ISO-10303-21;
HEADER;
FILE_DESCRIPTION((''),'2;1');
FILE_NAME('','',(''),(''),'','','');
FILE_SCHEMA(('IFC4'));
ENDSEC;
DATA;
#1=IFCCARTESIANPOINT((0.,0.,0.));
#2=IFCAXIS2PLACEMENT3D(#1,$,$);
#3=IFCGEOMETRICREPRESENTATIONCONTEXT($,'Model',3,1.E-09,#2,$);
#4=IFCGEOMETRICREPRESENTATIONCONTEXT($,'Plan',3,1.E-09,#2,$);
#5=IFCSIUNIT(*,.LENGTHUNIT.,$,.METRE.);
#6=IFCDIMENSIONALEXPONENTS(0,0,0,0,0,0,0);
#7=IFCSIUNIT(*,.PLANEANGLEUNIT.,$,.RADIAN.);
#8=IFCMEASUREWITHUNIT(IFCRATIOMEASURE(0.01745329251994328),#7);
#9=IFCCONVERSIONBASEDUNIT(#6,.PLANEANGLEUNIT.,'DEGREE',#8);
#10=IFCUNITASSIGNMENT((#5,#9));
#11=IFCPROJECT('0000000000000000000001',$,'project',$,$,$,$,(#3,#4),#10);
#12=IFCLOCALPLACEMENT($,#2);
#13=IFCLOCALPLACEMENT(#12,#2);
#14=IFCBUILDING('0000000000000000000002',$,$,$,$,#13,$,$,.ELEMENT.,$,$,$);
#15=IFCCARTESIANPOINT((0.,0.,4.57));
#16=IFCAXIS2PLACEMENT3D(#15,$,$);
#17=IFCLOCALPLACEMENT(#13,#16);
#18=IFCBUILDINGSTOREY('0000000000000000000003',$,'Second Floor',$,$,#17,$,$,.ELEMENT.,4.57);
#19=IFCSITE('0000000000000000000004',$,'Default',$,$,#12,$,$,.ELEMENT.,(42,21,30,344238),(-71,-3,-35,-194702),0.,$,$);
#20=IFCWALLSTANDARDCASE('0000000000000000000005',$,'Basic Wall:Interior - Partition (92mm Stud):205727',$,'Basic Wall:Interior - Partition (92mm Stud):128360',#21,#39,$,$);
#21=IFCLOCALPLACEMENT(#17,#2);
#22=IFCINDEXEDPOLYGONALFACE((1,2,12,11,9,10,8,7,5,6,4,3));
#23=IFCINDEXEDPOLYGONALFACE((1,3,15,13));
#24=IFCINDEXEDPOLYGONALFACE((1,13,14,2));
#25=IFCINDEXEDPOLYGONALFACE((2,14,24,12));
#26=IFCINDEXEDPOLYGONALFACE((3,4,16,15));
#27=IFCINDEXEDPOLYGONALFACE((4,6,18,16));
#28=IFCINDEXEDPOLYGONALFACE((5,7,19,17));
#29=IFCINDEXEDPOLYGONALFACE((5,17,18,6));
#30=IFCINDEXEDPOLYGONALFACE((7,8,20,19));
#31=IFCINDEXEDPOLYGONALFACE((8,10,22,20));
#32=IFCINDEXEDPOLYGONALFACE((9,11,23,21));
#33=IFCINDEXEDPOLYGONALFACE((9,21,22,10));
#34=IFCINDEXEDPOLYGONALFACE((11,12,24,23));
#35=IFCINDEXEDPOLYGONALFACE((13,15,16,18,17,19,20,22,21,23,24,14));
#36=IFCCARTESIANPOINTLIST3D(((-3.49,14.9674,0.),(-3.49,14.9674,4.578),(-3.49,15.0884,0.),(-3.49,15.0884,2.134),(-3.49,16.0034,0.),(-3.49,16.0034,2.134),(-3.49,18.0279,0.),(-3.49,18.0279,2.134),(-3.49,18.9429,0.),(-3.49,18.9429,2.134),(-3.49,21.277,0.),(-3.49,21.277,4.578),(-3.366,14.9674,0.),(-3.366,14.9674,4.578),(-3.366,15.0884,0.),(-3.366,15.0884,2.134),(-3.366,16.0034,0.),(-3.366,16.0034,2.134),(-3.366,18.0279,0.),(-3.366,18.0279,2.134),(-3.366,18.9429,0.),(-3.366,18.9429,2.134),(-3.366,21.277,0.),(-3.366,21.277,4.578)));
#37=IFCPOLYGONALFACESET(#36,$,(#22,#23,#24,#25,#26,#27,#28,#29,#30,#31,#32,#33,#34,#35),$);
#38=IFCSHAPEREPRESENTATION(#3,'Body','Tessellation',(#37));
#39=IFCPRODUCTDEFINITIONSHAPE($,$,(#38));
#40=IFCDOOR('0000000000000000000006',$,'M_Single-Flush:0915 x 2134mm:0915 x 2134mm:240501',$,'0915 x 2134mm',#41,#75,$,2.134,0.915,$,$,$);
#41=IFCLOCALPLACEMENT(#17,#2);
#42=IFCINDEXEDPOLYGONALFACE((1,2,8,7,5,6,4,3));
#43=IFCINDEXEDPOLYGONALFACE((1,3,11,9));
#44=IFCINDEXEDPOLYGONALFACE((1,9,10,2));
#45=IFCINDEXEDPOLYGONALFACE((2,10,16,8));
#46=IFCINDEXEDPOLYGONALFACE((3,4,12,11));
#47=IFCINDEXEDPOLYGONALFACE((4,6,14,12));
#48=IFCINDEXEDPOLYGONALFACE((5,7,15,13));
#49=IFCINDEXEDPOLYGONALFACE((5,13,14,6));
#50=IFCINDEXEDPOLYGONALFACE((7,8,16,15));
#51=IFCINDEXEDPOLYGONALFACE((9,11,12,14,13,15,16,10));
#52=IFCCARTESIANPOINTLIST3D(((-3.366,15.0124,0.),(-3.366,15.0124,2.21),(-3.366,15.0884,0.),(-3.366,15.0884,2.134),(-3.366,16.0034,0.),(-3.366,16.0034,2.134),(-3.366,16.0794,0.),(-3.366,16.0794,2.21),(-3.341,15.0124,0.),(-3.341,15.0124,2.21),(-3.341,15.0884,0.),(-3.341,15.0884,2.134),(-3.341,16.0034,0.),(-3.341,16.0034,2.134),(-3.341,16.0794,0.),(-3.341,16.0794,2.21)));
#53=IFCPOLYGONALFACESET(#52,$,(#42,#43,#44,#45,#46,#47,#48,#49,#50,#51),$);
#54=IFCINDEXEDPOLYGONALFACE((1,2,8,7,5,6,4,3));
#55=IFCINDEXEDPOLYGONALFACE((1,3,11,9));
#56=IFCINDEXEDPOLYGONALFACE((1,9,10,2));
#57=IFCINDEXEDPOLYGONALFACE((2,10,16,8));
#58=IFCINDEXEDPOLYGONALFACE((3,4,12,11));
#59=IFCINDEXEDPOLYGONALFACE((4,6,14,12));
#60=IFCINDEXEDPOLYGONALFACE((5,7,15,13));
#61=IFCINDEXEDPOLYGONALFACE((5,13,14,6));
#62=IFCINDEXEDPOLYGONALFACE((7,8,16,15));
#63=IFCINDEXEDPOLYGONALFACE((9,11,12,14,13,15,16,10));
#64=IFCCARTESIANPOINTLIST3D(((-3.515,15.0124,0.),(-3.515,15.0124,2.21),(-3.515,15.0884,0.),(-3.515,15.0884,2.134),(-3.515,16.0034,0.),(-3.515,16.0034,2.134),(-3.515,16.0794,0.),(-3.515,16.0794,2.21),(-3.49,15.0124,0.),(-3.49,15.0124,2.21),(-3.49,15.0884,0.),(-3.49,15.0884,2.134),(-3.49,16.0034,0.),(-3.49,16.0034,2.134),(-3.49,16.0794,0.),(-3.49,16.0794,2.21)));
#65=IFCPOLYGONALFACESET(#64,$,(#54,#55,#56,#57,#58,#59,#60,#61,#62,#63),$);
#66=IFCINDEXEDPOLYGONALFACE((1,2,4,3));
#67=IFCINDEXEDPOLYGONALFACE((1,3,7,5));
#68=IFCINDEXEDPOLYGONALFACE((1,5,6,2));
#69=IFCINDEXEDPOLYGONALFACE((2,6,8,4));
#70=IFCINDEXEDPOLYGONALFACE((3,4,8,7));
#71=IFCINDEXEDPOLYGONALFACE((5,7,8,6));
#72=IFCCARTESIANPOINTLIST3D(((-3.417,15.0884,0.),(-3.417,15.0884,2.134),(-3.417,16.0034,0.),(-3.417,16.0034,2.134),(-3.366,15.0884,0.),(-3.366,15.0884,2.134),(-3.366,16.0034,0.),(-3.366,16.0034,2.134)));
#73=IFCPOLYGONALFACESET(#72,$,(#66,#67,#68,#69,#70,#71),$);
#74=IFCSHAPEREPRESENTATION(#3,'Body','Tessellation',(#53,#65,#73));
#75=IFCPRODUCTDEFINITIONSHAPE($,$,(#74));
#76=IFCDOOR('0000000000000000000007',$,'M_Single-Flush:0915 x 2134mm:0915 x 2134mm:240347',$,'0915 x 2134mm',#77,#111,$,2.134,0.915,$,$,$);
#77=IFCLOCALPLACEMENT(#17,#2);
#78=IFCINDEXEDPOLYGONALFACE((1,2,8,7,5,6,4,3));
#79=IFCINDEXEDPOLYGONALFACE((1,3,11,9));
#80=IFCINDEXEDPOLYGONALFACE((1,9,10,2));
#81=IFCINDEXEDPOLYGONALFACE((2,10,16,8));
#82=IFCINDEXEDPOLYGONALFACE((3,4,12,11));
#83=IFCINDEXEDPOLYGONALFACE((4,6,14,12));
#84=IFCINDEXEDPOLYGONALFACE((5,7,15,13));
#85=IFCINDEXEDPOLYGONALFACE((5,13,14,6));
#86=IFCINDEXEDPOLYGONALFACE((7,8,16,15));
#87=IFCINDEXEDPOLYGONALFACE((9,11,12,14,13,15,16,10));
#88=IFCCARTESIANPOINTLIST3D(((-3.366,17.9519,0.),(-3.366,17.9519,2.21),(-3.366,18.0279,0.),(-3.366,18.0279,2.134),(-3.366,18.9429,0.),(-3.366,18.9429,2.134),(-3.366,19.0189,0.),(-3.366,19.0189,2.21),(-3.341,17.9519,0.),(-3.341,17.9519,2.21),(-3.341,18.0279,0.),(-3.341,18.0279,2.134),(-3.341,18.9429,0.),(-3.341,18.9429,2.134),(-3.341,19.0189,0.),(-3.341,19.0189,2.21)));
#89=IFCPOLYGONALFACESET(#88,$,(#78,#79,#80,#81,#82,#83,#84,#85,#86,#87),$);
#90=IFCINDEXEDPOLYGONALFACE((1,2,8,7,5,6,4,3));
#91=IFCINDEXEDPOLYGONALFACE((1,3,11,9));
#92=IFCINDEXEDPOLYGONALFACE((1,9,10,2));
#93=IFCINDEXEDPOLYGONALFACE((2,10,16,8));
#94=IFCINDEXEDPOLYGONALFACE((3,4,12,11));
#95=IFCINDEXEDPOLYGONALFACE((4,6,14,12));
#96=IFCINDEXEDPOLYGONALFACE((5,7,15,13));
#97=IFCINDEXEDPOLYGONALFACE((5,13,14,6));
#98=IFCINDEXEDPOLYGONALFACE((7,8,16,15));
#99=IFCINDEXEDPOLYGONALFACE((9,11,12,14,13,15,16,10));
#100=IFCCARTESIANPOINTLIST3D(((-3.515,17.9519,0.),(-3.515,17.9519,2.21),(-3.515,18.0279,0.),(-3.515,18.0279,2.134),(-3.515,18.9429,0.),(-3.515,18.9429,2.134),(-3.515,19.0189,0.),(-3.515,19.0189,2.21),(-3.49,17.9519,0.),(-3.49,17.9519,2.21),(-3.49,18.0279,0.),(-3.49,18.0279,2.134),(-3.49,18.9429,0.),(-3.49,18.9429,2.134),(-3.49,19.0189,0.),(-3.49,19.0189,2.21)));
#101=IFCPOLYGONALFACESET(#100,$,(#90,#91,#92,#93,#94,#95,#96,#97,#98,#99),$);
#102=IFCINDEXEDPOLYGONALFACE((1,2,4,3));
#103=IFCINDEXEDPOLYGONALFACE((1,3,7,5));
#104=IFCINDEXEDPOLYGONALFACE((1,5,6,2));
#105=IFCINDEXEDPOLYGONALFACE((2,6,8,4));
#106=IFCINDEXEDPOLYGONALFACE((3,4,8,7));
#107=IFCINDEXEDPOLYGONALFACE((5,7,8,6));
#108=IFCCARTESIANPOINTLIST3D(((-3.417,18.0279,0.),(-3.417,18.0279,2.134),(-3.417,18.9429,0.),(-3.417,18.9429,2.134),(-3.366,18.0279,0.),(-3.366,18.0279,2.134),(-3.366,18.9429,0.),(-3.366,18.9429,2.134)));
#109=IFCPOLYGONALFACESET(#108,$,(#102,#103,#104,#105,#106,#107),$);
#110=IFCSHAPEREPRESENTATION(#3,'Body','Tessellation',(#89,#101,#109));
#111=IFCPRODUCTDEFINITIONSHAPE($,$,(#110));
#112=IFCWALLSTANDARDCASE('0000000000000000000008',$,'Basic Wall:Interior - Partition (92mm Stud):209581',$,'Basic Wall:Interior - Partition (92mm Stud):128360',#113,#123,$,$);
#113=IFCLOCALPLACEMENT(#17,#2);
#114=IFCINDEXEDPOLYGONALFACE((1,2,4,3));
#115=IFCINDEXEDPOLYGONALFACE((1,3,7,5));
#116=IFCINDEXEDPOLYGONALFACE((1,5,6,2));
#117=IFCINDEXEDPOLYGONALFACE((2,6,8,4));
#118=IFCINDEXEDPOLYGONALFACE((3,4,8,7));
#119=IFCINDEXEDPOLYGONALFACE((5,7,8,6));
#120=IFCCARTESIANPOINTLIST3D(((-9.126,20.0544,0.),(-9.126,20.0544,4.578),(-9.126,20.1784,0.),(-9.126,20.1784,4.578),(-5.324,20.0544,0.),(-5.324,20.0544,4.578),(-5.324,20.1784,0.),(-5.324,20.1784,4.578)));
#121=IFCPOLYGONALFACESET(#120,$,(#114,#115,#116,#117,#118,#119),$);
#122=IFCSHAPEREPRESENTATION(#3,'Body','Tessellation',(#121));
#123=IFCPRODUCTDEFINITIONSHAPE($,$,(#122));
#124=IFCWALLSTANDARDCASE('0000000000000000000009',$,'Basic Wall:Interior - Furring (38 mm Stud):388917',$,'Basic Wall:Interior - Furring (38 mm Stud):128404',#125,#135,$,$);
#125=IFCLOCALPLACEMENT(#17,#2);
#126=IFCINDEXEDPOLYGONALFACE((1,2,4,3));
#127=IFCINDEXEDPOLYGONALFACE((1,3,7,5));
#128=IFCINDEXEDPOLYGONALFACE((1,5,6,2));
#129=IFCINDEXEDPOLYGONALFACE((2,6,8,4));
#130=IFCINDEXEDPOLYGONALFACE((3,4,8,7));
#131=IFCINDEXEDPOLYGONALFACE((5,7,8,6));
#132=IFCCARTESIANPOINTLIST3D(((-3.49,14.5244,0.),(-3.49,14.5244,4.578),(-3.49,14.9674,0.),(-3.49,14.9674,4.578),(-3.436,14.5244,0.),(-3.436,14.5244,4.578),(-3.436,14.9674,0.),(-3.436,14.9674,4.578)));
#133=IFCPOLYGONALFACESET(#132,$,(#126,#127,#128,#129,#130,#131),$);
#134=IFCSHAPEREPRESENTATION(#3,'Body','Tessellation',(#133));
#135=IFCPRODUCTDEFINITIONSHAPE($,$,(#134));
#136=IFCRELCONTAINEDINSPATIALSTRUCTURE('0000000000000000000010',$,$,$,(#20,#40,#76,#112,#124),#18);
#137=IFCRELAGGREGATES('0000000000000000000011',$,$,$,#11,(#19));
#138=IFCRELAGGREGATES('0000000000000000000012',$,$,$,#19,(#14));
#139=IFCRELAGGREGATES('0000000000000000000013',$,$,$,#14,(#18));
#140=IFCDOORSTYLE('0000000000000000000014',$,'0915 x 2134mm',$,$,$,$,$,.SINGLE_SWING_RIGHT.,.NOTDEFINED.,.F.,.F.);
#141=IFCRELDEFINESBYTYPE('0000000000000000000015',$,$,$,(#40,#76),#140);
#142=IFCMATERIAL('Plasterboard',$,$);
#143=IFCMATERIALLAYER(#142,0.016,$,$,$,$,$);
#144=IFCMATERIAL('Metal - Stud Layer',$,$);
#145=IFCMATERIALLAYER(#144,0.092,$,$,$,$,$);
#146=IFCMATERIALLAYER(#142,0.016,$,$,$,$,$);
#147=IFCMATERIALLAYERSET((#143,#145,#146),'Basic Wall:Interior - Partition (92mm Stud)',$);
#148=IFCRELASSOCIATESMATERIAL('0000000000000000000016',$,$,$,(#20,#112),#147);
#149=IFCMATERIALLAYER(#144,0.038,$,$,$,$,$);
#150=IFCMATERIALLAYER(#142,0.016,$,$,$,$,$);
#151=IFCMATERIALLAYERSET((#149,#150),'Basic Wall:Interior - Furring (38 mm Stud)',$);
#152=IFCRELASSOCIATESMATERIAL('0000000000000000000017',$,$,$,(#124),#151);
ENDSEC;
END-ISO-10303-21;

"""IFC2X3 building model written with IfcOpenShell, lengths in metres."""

from ifc_helpers import new_model, entity, si_unit, converted_unit, frame, frame_2d, origin, origin_2d_with_axis, place, context, project, spatial, polyline, rectangle, outline, extrude, source, transform, mapped, material, layer, layer_set, layer_usage, type_object, type_shapes, element, fill, save


model = new_model("IFC2X3")

# Units and contexts
model_context = context("Model", 3, precision=1e-09, world=origin())
plan_context = context("Plan", 3, precision=1e-09, world=origin())
ifc_project = project(units=[si_unit("LENGTHUNIT", "METRE"), converted_unit("PLANEANGLEUNIT", "DEGREE", entity("IfcRatioMeasure", 0.01745329251994328), si_unit("PLANEANGLEUNIT", "RADIAN"), dimensions=[0, 0, 0, 0, 0, 0, 0])], contexts=[model_context, plan_context])

# Site, building, storey
site_placement = place(None, origin())
site = spatial("IfcSite", under=ifc_project, at=site_placement, Name="Default", CompositionType="ELEMENT", RefLatitude=(42, 21, 30, 344238), RefLongitude=(-71, -3, -35, -194702), RefElevation=0.0)
building_placement = place(site_placement, origin())
building = spatial("IfcBuilding", under=site, at=building_placement, CompositionType="ELEMENT")
storey_placement = place(building_placement, frame((0.0, 0.0, 4.57)))
storey = spatial("IfcBuildingStorey", under=building, at=storey_placement, Name="Second Floor", CompositionType="ELEMENT", Elevation=4.57)

# Wall, openings, doors
ifc_material_1 = material(Name="Plasterboard")
ifc_layer_1 = layer(ifc_material_1, 0.016)
ifc_material_2 = material(Name="Metal - Stud Layer")
ifc_layer_2 = layer(ifc_material_2, 0.092)
ifc_layer_3 = layer(ifc_material_1, 0.016)
ifc_layer_set_1 = layer_set([ifc_layer_1, ifc_layer_2, ifc_layer_3], Name="Basic Wall:Interior - Partition (92mm Stud)")
ifc_layer_usage_1 = layer_usage(ifc_layer_set_1, "AXIS2", "NEGATIVE", 0.062)
wall_1_placement = place(storey_placement, frame((-3.428, 21.277, 0.0), z_axis=(0.0, 0.0, 1.0), x_axis=(0.0, -1.0, 0.0)))
wall_1 = element("IfcWallStandardCase", 1, at=wall_1_placement, inside=storey, material=ifc_layer_usage_1, Name="Basic Wall:Interior - Partition (92mm Stud):205727", ObjectType="Basic Wall:Interior - Partition (92mm Stud):128360", context=model_context, shape_type="SweptSolid", body=[
    extrude(rectangle(XDim=6.3096, YDim=0.124, at=frame_2d((3.1548, 0.0), x_axis=(-1.0, 0.0))), origin(), (0.0, 0.0, 1.0), 4.578),
])
opening_1_placement = place(wall_1_placement, frame((2.3341, -0.062, 0.0)))
opening_1 = element("IfcOpeningElement", 2, at=opening_1_placement, cuts=wall_1, ObjectType="Opening", context=model_context, shape_type="SweptSolid", body=[
    extrude(rectangle(XDim=0.915, YDim=2.134, at=frame_2d((1.067, 0.4575), x_axis=(0.0, 1.0))), frame((0.0, 0.0, 0.0), z_axis=(0.0, 1.0, 0.0), x_axis=(0.0, 0.0, 1.0)), (0.0, 0.0, 1.0), 0.124),
])
opening_2_placement = place(wall_1_placement, frame((5.2736, -0.062, 0.0)))
opening_2 = element("IfcOpeningElement", 3, at=opening_2_placement, cuts=wall_1, ObjectType="Opening", context=model_context, shape_type="SweptSolid", body=[
    extrude(rectangle(XDim=0.915, YDim=2.134, at=frame_2d((1.067, 0.4575), x_axis=(0.0, 1.0))), frame((0.0, 0.0, 0.0), z_axis=(0.0, 1.0, 0.0), x_axis=(0.0, 0.0, 1.0)), (0.0, 0.0, 1.0), 0.124),
])
door_style_1 = type_object("IfcDoorStyle", Name="0915 x 2134mm", ConstructionType="NOTDEFINED", OperationType="SINGLE_SWING_RIGHT", ParameterTakesPrecedence=False, Sizeable=False)
shared_shape_1 = source(origin(), model_context, "Body", "SweptSolid", [
    extrude(outline(polyline([(-0.5335, -1.124), (0.5335, -1.124), (0.5335, 1.086), (0.4575, 1.086), (0.4575, -1.048), (-0.4575, -1.048), (-0.4575, 1.086), (-0.5335, 1.086), (-0.5335, -1.124)])), frame((0.4575, 0.124, 1.086), z_axis=(0.0, 1.0, 0.0), x_axis=(1.0, 0.0, 0.0)), (0.0, 0.0, 1.0), 0.025),
    extrude(outline(polyline([(-1.124, -0.5335), (1.086, -0.5335), (1.086, -0.4575), (-1.048, -0.4575), (-1.048, 0.4575), (1.086, 0.4575), (1.086, 0.5335), (-1.124, 0.5335), (-1.124, -0.5335)])), frame((0.4575, -0.025, 1.086), z_axis=(0.0, 1.0, 0.0), x_axis=(0.0, 0.0, -1.0)), (0.0, 0.0, 1.0), 0.025),
    extrude(rectangle(XDim=0.051, YDim=0.915, at=origin_2d_with_axis()), frame((0.4575, 0.0985, 0.0), z_axis=(0.0, 0.0, 1.0), x_axis=(0.0, 1.0, 0.0)), (0.0, 0.0, 1.0), 2.134),
])
type_shapes(door_style_1, [shared_shape_1])
door_1_placement = place(opening_2_placement, origin())
door_1 = element("IfcDoor", 4, at=door_1_placement, inside=storey, type_object=door_style_1, Name="M_Single-Flush:0915 x 2134mm:0915 x 2134mm:240501", ObjectType="0915 x 2134mm", OverallHeight=2.134, OverallWidth=0.915, context=model_context, shape_type="MappedRepresentation", body=[
    mapped(shared_shape_1, transform((0.0, 0.0, 0.0), scale=1.0)),
])
fill(opening_2, door_1)
door_2_placement = place(opening_1_placement, origin())
door_2 = element("IfcDoor", 5, at=door_2_placement, inside=storey, type_object=door_style_1, Name="M_Single-Flush:0915 x 2134mm:0915 x 2134mm:240347", ObjectType="0915 x 2134mm", OverallHeight=2.134, OverallWidth=0.915, context=model_context, shape_type="MappedRepresentation", body=[
    mapped(shared_shape_1, transform((0.0, 0.0, 0.0), scale=1.0)),
])
fill(opening_1, door_2)

# Walls
wall_2_placement = place(storey_placement, frame((-5.324, 20.1164, 0.0), z_axis=(0.0, 0.0, 1.0), x_axis=(-1.0, 0.0, 0.0)))
element("IfcWallStandardCase", 6, at=wall_2_placement, inside=storey, material=ifc_layer_usage_1, Name="Basic Wall:Interior - Partition (92mm Stud):209581", ObjectType="Basic Wall:Interior - Partition (92mm Stud):128360", context=model_context, shape_type="SweptSolid", body=[
    extrude(rectangle(XDim=3.802, YDim=0.124, at=frame_2d((1.901, 0.0), x_axis=(-1.0, 0.0))), origin(), (0.0, 0.0, 1.0), 4.578),
])
ifc_layer_4 = layer(ifc_material_2, 0.038)
ifc_layer_5 = layer(ifc_material_1, 0.016)
ifc_layer_set_2 = layer_set([ifc_layer_4, ifc_layer_5], Name="Basic Wall:Interior - Furring (38 mm Stud)")
ifc_layer_usage_2 = layer_usage(ifc_layer_set_2, "AXIS2", "NEGATIVE", 0.027)
wall_3_placement = place(storey_placement, frame((-3.463, 14.9674, 0.0), z_axis=(0.0, 0.0, 1.0), x_axis=(0.0, -1.0, 0.0)))
element("IfcWallStandardCase", 7, at=wall_3_placement, inside=storey, material=ifc_layer_usage_2, Name="Basic Wall:Interior - Furring (38 mm Stud):388917", ObjectType="Basic Wall:Interior - Furring (38 mm Stud):128404", context=model_context, shape_type="SweptSolid", body=[
    extrude(rectangle(XDim=0.443, YDim=0.054, at=frame_2d((0.2215, 0.0), x_axis=(-1.0, 0.0))), origin(), (0.0, 0.0, 1.0), 4.578),
])

save(model, "model.ifc")
